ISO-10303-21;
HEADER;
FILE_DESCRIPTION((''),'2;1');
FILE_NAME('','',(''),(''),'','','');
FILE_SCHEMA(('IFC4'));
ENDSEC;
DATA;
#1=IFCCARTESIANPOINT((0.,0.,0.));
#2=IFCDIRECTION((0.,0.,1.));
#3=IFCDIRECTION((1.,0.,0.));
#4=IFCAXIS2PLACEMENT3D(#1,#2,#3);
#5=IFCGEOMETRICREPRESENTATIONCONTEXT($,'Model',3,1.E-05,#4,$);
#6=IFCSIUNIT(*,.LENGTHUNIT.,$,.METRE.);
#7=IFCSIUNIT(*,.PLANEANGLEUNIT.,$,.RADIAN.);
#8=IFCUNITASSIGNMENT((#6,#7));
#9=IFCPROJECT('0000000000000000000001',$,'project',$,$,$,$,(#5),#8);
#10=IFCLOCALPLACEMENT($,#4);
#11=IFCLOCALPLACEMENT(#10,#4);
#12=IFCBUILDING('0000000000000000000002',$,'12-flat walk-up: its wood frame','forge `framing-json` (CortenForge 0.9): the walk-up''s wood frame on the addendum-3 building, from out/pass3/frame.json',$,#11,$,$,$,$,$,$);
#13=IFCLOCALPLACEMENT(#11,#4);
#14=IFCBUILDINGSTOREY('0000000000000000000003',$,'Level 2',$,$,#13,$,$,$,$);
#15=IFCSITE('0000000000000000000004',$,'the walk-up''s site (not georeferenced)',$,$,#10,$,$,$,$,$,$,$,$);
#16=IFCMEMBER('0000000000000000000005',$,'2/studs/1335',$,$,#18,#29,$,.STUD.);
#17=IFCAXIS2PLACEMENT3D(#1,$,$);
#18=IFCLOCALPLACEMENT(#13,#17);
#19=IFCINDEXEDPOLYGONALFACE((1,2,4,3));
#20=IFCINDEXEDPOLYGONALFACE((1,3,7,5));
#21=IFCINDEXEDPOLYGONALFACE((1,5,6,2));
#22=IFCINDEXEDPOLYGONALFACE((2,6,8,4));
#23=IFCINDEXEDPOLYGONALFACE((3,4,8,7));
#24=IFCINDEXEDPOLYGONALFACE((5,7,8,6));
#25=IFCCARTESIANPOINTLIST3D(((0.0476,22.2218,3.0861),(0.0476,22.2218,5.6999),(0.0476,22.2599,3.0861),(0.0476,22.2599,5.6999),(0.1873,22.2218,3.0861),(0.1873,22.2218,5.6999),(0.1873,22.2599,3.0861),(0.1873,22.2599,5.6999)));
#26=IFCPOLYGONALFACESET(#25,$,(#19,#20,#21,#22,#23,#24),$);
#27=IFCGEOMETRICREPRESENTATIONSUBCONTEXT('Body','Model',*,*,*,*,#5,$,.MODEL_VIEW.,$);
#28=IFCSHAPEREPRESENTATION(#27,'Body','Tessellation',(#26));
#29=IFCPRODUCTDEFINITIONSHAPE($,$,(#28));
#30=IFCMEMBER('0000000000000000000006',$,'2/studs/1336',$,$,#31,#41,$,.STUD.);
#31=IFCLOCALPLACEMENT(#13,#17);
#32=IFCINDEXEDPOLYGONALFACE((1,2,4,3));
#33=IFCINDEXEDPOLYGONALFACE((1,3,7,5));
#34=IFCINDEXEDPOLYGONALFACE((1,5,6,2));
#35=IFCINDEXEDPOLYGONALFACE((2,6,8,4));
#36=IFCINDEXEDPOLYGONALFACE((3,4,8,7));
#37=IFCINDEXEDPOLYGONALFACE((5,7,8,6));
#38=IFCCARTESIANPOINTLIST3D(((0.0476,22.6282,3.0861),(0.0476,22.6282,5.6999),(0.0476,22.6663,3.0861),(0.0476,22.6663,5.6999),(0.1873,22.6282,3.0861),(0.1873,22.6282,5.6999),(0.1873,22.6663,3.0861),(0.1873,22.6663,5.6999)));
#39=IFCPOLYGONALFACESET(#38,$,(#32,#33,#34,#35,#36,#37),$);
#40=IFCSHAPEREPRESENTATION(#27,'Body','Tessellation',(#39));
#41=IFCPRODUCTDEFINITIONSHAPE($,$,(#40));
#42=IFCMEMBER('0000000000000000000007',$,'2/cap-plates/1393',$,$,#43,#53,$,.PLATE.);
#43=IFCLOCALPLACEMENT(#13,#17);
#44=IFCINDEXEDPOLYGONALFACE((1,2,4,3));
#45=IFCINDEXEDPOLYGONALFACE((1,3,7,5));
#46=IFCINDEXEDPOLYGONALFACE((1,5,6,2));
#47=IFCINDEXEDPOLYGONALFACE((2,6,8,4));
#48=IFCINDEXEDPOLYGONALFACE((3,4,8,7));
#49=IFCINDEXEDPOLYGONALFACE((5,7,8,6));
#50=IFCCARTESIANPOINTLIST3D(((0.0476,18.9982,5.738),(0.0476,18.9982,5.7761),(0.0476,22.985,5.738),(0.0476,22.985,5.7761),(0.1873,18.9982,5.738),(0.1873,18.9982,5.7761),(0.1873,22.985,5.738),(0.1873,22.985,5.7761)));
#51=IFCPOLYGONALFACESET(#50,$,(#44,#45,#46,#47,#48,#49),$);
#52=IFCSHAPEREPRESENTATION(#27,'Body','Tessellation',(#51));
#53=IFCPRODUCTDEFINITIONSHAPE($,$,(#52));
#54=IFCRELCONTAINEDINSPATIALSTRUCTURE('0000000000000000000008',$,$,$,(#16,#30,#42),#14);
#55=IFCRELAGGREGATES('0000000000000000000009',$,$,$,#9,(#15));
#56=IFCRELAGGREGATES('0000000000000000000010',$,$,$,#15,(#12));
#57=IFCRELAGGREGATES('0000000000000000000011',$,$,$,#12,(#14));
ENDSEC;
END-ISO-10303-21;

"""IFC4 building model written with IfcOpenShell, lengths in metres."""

from ifc_helpers import new_model, si_unit, frame, frame_2d, origin, origin_with_axes, place, context, subcontext, project, spatial, rectangle, extrude, element, save


model = new_model("IFC4")

# Units and contexts
model_context = context("Model", 3, precision=1e-05, world=origin_with_axes())
body_context = subcontext(model_context, "Body", "Model", "MODEL_VIEW")
ifc_project = project(units=[si_unit("LENGTHUNIT", "METRE"), si_unit("PLANEANGLEUNIT", "RADIAN")], contexts=[model_context])

# Site, building, storey
site_placement = place(None, origin_with_axes())
site = spatial("IfcSite", under=ifc_project, at=site_placement, Name="the walk-up's site (not georeferenced)")
building_placement = place(site_placement, origin_with_axes())
building = spatial("IfcBuilding", under=site, at=building_placement, Name="12-flat walk-up: its wood frame", Description="forge `framing-json` (CortenForge 0.9): the walk-up's wood frame on the addendum-3 building, from out/pass3/frame.json")
storey_placement = place(building_placement, origin_with_axes())
storey = spatial("IfcBuildingStorey", under=building, at=storey_placement, Name="Level 2")

# Members
for number, where, z_axis, x_axis, name in (
    (1, (0.0476, 22.2218, 3.0861), (0.0, 0.0, 1.0), (1.0, 0.0, 0.0), "2/studs/1335"),
    (2, (0.0476, 22.6282, 3.0861), (0.0, 0.0, 1.0), (1.0, 0.0, 0.0), "2/studs/1336"),
):
    element("IfcMember", number, at=place(storey_placement, frame(where, z_axis=z_axis, x_axis=x_axis)), inside=storey, Name=name, PredefinedType="STUD", context=body_context, shape_type="SweptSolid", body=[
        extrude(rectangle(XDim=0.1397, YDim=0.0381, at=frame_2d((0.0698, 0.0191))), origin(), (0.0, 0.0, 1.0), 2.6138),
    ])
member_1_placement = place(storey_placement, frame((0.0476, 18.9982, 5.738), z_axis=(0.0, 0.0, 1.0), x_axis=(1.0, 0.0, 0.0)))
element("IfcMember", 3, at=member_1_placement, inside=storey, Name="2/cap-plates/1393", PredefinedType="PLATE", context=body_context, shape_type="SweptSolid", body=[
    extrude(rectangle(XDim=0.1397, YDim=3.9868, at=frame_2d((0.0698, 1.9934))), origin(), (0.0, 0.0, 1.0), 0.0381),
])

save(model, "model.ifc")
